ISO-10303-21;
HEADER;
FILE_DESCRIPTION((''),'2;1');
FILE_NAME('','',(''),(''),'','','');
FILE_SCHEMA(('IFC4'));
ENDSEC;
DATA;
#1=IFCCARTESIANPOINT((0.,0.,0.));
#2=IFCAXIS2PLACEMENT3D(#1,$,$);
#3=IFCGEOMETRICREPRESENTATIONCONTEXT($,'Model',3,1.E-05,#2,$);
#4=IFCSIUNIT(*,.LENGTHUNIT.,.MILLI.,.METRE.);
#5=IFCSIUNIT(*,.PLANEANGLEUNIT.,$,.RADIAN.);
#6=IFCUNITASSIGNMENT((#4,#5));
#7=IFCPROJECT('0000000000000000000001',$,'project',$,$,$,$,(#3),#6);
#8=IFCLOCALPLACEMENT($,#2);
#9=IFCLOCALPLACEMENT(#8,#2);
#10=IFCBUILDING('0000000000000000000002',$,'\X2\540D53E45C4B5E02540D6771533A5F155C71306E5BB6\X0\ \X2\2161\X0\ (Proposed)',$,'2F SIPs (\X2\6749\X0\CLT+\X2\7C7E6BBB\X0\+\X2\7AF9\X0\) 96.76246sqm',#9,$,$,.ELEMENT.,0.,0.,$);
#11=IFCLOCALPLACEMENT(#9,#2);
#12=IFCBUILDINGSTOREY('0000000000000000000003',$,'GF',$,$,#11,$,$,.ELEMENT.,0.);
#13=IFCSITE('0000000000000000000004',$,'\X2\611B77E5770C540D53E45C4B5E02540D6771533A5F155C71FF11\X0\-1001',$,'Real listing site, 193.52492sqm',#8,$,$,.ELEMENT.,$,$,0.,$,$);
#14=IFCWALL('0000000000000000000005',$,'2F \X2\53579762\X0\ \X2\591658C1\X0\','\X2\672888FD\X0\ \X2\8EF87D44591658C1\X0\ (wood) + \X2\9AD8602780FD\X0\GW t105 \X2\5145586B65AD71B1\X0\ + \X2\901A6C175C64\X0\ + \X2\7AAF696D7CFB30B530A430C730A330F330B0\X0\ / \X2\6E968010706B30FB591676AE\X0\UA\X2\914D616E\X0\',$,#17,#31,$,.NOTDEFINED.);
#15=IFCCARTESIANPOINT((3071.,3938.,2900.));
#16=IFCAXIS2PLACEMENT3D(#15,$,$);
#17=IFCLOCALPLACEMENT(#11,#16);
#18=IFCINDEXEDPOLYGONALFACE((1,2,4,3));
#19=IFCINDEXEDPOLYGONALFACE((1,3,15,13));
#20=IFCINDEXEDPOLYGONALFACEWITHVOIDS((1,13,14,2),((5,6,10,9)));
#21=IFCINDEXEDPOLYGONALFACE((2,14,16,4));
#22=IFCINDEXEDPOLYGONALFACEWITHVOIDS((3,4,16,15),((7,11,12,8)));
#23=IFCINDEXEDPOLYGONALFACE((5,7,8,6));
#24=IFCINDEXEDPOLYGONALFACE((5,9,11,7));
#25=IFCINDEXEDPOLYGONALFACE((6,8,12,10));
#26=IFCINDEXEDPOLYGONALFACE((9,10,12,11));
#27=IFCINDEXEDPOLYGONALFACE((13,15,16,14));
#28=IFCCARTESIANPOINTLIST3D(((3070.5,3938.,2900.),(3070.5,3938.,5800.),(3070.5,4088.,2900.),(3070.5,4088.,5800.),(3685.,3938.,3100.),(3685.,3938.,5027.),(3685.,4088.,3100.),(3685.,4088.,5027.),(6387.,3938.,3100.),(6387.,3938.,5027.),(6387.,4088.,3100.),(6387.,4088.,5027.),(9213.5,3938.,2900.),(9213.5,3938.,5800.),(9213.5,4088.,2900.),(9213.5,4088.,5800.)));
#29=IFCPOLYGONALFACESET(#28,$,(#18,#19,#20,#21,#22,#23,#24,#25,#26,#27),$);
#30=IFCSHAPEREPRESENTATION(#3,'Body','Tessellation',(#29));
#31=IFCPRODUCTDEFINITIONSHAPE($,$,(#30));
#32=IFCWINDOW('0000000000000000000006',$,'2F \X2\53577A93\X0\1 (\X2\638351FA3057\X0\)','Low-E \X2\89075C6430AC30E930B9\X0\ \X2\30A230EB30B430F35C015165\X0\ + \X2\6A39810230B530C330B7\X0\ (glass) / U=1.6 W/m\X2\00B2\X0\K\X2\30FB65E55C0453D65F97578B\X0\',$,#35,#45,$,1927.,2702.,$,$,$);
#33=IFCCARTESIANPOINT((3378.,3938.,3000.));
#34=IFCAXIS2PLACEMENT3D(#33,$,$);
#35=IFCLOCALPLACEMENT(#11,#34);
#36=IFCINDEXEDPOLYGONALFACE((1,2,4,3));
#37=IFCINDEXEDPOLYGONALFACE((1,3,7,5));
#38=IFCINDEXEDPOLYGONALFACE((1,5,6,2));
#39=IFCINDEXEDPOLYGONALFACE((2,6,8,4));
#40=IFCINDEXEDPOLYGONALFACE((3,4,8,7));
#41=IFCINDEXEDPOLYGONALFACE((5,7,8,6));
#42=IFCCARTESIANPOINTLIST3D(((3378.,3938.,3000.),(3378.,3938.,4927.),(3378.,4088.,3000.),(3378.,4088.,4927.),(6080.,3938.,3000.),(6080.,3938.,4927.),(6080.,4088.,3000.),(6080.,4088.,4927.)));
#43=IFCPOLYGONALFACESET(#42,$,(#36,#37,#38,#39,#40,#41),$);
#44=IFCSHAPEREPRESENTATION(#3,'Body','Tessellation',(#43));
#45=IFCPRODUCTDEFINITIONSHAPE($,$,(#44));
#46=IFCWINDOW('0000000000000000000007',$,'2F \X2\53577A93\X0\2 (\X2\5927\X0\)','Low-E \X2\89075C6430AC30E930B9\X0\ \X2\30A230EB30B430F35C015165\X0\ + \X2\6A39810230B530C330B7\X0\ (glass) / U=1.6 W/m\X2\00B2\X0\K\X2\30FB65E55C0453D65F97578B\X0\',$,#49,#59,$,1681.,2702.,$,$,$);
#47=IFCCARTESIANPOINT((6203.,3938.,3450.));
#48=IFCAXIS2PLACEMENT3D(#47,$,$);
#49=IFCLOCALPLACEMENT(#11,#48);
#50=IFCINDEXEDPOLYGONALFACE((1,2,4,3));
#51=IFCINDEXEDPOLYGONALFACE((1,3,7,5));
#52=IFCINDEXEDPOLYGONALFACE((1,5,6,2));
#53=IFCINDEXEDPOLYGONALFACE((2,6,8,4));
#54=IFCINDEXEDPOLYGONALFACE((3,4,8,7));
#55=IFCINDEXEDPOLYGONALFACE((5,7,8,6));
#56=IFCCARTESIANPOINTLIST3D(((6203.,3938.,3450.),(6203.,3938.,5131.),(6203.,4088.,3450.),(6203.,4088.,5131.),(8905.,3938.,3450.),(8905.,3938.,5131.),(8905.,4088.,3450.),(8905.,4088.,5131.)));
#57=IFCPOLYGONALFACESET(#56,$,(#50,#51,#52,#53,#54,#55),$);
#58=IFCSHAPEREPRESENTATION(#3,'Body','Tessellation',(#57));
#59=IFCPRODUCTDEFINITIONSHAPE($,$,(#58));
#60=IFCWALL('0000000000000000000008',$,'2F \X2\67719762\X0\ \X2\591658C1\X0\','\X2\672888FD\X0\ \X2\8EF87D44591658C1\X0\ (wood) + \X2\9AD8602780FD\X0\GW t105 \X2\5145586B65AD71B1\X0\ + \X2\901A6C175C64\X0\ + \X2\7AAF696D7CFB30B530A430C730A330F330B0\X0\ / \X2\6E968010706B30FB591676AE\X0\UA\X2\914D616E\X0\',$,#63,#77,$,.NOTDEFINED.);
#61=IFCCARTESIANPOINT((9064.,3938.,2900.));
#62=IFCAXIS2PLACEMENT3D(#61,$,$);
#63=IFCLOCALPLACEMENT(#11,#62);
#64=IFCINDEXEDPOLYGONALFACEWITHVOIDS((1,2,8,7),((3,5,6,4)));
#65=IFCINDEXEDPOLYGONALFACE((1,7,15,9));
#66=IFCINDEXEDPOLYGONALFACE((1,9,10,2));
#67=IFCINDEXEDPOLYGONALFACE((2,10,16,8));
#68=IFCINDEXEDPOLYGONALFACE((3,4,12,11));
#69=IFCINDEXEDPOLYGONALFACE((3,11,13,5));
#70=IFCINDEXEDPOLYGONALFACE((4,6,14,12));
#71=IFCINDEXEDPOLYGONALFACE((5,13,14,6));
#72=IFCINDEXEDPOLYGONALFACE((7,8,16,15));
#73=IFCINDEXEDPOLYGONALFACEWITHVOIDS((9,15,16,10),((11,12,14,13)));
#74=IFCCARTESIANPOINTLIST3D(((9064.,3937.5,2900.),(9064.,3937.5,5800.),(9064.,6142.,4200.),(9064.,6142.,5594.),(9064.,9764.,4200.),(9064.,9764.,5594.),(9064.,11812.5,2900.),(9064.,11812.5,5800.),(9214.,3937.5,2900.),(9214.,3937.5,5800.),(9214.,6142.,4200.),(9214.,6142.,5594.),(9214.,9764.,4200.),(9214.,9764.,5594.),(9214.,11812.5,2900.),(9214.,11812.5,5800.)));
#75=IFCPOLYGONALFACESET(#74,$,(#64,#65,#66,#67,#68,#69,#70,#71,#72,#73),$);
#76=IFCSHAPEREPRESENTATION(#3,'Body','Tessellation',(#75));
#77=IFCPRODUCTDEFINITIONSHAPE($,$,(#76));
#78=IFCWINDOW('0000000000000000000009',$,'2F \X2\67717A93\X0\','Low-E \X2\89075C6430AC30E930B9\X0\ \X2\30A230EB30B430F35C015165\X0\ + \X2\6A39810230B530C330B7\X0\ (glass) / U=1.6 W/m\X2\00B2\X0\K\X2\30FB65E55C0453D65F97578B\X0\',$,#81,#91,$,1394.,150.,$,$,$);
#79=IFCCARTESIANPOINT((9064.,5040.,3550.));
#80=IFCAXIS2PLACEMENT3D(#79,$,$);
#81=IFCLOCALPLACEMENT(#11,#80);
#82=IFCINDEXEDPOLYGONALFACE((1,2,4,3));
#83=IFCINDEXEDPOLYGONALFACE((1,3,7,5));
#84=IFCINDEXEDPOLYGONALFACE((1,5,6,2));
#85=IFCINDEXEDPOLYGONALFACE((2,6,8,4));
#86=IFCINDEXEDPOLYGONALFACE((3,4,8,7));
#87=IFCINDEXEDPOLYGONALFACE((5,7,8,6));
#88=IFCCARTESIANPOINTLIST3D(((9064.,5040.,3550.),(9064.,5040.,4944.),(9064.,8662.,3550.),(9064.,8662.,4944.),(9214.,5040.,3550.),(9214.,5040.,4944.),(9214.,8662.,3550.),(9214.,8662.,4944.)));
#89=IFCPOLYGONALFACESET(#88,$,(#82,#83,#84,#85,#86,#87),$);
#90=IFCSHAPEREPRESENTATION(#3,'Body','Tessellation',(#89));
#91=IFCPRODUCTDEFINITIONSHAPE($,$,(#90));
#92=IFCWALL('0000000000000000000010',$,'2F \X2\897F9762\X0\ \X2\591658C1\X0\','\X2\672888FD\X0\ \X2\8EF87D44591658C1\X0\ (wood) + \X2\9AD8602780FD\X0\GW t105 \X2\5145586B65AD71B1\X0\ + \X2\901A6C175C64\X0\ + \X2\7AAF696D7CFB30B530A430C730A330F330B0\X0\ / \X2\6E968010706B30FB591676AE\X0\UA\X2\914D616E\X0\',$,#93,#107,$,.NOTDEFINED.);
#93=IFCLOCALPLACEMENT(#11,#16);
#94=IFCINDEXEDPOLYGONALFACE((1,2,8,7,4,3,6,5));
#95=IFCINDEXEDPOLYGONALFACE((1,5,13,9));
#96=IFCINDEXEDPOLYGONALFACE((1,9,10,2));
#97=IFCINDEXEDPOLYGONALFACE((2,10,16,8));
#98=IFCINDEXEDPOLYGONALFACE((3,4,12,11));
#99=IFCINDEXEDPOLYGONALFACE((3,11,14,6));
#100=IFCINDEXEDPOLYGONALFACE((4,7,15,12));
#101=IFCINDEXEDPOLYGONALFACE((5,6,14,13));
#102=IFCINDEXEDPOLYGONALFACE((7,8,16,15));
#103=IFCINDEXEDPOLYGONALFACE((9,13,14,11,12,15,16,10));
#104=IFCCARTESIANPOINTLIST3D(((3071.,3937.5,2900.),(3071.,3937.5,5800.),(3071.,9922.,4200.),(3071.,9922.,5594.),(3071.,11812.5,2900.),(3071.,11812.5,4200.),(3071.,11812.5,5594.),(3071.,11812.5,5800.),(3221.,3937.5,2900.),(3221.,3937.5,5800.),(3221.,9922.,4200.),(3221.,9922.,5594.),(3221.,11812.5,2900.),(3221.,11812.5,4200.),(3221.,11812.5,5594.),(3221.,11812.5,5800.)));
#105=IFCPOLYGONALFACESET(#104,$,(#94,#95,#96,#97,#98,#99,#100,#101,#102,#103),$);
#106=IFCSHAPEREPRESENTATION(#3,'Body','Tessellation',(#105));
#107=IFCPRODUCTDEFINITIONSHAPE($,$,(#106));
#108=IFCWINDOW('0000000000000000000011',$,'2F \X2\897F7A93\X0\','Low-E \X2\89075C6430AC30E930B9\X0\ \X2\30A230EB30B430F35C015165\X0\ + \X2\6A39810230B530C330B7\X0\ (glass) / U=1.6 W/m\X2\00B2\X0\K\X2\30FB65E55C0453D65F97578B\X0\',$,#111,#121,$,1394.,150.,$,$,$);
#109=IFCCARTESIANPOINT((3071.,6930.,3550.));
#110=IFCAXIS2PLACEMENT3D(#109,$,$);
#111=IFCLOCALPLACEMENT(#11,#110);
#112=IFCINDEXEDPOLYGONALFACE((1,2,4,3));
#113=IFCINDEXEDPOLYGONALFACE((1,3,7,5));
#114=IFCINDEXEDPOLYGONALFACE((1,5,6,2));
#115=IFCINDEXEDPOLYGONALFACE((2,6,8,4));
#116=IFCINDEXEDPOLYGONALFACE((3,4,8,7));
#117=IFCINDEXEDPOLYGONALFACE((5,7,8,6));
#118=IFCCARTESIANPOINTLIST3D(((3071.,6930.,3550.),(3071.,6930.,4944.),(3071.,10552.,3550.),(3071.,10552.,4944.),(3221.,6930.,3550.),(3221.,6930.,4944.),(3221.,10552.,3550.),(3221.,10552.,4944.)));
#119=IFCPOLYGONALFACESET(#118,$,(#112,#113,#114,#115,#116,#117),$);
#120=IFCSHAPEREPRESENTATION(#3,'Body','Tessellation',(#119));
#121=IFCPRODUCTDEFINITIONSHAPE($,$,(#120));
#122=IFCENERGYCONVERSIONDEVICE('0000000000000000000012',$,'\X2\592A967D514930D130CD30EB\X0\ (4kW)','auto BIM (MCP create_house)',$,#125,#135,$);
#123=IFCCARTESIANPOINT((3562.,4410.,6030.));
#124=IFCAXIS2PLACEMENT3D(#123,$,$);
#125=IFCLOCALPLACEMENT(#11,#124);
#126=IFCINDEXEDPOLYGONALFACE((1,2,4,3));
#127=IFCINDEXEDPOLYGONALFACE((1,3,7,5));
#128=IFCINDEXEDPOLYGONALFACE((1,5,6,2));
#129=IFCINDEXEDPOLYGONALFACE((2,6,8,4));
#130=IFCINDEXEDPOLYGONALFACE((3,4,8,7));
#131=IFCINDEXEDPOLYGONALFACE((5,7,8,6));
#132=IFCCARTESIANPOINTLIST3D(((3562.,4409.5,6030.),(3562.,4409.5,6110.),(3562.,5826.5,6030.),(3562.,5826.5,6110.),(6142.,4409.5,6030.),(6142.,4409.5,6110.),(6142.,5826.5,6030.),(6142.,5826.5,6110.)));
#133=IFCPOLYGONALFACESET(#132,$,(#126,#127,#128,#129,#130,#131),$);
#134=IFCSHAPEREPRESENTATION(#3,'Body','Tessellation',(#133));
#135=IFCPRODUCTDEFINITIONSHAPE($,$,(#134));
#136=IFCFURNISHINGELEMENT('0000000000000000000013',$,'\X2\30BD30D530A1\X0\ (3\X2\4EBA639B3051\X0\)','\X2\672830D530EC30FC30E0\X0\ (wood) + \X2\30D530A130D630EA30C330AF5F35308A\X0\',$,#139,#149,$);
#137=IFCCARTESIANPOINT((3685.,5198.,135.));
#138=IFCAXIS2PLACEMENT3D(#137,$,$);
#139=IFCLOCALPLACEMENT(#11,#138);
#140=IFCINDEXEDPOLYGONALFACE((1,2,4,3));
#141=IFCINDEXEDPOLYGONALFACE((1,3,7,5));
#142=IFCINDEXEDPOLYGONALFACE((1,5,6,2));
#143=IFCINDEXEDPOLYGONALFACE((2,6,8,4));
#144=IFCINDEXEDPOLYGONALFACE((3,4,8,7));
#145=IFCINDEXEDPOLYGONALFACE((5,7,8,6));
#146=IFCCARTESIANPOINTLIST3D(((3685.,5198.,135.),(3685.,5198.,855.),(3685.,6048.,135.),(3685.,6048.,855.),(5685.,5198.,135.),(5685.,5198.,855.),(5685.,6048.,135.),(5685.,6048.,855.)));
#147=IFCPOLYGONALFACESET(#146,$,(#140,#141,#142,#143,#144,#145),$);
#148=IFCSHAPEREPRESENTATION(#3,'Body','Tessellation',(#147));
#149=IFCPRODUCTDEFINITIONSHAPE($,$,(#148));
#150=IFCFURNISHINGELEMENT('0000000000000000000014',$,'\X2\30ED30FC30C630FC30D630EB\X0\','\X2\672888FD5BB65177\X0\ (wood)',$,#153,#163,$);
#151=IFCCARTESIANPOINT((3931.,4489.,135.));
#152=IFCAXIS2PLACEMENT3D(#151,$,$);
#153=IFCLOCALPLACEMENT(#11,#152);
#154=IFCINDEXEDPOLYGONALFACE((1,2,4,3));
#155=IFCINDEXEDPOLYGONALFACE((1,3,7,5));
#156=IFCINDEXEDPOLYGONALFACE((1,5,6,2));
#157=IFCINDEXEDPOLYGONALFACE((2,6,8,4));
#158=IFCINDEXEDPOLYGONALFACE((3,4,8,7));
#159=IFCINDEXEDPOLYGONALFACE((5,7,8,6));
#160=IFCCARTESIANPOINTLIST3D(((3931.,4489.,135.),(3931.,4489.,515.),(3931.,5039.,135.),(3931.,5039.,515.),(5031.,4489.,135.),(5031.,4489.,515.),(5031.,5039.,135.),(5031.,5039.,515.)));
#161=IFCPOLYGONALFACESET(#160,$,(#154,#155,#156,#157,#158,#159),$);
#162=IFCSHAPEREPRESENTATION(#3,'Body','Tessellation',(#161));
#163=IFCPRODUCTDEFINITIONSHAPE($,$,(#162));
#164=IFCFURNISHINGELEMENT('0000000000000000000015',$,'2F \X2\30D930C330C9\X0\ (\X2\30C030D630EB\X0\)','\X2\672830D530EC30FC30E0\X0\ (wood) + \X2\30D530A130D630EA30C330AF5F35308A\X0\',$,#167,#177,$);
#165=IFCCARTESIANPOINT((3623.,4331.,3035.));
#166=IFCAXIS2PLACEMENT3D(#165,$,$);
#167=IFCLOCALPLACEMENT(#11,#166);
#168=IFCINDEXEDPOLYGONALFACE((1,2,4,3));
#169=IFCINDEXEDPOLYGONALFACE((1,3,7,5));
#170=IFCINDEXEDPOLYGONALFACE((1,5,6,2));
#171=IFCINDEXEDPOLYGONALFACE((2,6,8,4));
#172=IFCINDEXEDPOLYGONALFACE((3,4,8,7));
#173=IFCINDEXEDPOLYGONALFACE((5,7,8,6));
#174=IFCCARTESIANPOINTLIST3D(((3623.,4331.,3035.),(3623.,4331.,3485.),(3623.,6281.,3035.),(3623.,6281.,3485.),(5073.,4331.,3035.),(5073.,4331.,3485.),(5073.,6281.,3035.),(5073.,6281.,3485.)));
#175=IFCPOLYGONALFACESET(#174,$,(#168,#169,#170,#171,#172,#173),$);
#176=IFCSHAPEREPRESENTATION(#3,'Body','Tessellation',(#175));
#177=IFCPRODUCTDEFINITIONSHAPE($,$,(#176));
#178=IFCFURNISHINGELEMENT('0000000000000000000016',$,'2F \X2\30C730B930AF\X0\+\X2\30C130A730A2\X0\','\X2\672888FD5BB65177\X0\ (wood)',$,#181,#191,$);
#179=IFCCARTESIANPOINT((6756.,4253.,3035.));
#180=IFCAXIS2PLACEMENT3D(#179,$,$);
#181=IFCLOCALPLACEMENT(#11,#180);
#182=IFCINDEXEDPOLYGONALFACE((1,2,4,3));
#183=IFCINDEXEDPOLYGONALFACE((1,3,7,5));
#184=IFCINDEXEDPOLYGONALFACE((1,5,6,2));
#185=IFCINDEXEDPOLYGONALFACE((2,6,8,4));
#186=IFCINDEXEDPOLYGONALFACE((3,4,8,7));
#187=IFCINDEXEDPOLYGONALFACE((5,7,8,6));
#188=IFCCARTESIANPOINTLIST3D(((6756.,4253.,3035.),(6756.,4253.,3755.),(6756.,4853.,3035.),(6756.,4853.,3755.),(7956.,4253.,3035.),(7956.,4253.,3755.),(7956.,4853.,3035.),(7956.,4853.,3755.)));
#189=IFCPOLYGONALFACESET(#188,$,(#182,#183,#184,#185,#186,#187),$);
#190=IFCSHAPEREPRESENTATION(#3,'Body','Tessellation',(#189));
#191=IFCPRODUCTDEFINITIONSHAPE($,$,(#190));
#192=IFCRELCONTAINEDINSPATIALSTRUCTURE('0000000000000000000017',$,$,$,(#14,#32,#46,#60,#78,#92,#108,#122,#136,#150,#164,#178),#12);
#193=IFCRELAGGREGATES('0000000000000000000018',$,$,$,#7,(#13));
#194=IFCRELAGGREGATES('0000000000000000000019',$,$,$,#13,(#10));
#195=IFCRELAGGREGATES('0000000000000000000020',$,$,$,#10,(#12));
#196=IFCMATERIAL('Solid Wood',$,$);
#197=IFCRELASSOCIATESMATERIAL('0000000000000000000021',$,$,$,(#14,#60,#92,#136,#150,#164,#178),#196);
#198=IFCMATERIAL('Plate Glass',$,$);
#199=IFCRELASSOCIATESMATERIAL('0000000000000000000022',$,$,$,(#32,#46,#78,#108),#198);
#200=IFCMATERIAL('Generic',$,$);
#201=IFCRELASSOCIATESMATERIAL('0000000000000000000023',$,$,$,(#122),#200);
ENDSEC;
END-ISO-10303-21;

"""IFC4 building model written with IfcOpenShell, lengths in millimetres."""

from ifc_helpers import new_model, si_unit, frame, frame_2d, origin, place, context, project, spatial, rectangle, extrude, material, element, fill, save


model = new_model("IFC4")

# Units and contexts
model_context = context("Model", 3, precision=1e-05, world=origin())
ifc_project = project(units=[si_unit("LENGTHUNIT", "METRE", prefix="MILLI"), si_unit("PLANEANGLEUNIT", "RADIAN")], contexts=[model_context])

# Site, building, storey
site_placement = place(None, origin())
site = spatial("IfcSite", under=ifc_project, at=site_placement, Name="愛知県名古屋市名東区引山１-1001", ObjectType="Real listing site, 193.52492sqm", CompositionType="ELEMENT", RefElevation=0.0)
building_placement = place(site_placement, origin())
building = spatial("IfcBuilding", under=site, at=building_placement, Name="名古屋市名東区引山の家 Ⅱ (Proposed)", ObjectType="2F SIPs (杉CLT+籾殻+竹) 96.76246sqm", CompositionType="ELEMENT", ElevationOfRefHeight=0.0, ElevationOfTerrain=0.0)
storey_placement = place(building_placement, origin())
storey = spatial("IfcBuildingStorey", under=building, at=storey_placement, Name="GF", CompositionType="ELEMENT", Elevation=0.0)

# Shared definitions
ifc_material_1 = material(Name="Solid Wood")

# Wall, openings, windows
wall_1_placement = place(storey_placement, frame((3071.0, 3938.0, 2900.0)))
wall_1 = element("IfcWall", 1, at=wall_1_placement, inside=storey, material=ifc_material_1, Name="2F 南面 外壁", Description="木製 軸組外壁 (wood) + 高性能GW t105 充填断熱 + 通気層 + 窯業系サイディング / 準耐火・外皮UA配慮", PredefinedType="NOTDEFINED", context=model_context, shape_type="SweptSolid", body=[
    extrude(rectangle(XDim=6143.0, YDim=150.0, at=frame_2d((3071.0, 75.0))), frame((3071.0, 3938.0, 2900.0)), (0.0, 0.0, 1.0), 2900.0),
])
opening_1_placement = place(storey_placement, frame((3378.0, 3938.0, 3000.0)))
opening_1 = element("IfcOpeningElement", 2, at=opening_1_placement, cuts=wall_1, PredefinedType="NOTDEFINED", context=model_context, shape_type="SweptSolid", body=[
    extrude(rectangle(XDim=2702.0, YDim=150.0, at=frame_2d((1351.0, 75.0))), frame((3378.0, 3938.0, 3000.0)), (0.0, 0.0, 1.0), 1927.0),
])
opening_2_placement = place(storey_placement, frame((6203.0, 3938.0, 3450.0)))
opening_2 = element("IfcOpeningElement", 3, at=opening_2_placement, cuts=wall_1, PredefinedType="NOTDEFINED", context=model_context, shape_type="SweptSolid", body=[
    extrude(rectangle(XDim=2702.0, YDim=150.0, at=frame_2d((1351.0, 75.0))), frame((6203.0, 3938.0, 3450.0)), (0.0, 0.0, 1.0), 1681.0),
])
ifc_material_2 = material(Name="Plate Glass")
window_1_placement = place(storey_placement, frame((3378.0, 3938.0, 3000.0)))
window_1 = element("IfcWindow", 4, at=window_1_placement, inside=storey, material=ifc_material_2, Name="2F 南窓1 (掃出し)", Description="Low-E 複層ガラス アルゴン封入 + 樹脂サッシ (glass) / U=1.6 W/m²K・日射取得型", OverallHeight=1927.0, OverallWidth=2702.0, context=model_context, shape_type="SweptSolid", body=[
    extrude(rectangle(XDim=2702.0, YDim=150.0, at=frame_2d((1351.0, 75.0))), frame((3378.0, 3938.0, 3000.0)), (0.0, 0.0, 1.0), 1927.0),
])
fill(opening_1, window_1)
window_2_placement = place(storey_placement, frame((6203.0, 3938.0, 3450.0)))
window_2 = element("IfcWindow", 5, at=window_2_placement, inside=storey, material=ifc_material_2, Name="2F 南窓2 (大)", Description="Low-E 複層ガラス アルゴン封入 + 樹脂サッシ (glass) / U=1.6 W/m²K・日射取得型", OverallHeight=1681.0, OverallWidth=2702.0, context=model_context, shape_type="SweptSolid", body=[
    extrude(rectangle(XDim=2702.0, YDim=150.0, at=frame_2d((1351.0, 75.0))), frame((6203.0, 3938.0, 3450.0)), (0.0, 0.0, 1.0), 1681.0),
])
fill(opening_2, window_2)

# Walls, openings, windows
wall_2_placement = place(storey_placement, frame((9064.0, 3938.0, 2900.0)))
wall_2 = element("IfcWall", 6, at=wall_2_placement, inside=storey, material=ifc_material_1, Name="2F 東面 外壁", Description="木製 軸組外壁 (wood) + 高性能GW t105 充填断熱 + 通気層 + 窯業系サイディング / 準耐火・外皮UA配慮", PredefinedType="NOTDEFINED", context=model_context, shape_type="SweptSolid", body=[
    extrude(rectangle(XDim=150.0, YDim=7875.0, at=frame_2d((75.0, 3937.0))), frame((9064.0, 3938.0, 2900.0)), (0.0, 0.0, 1.0), 2900.0),
])
opening_3_placement = place(storey_placement, frame((9064.0, 5040.0, 3550.0)))
opening_3 = element("IfcOpeningElement", 7, at=opening_3_placement, cuts=wall_2, PredefinedType="NOTDEFINED", context=model_context, shape_type="SweptSolid", body=[
    extrude(rectangle(XDim=150.0, YDim=3622.0, at=frame_2d((75.0, 1811.0))), frame((9064.0, 5040.0, 3550.0)), (0.0, 0.0, 1.0), 1394.0),
])
window_3_placement = place(storey_placement, frame((9064.0, 5040.0, 3550.0)))
window_3 = element("IfcWindow", 8, at=window_3_placement, inside=storey, material=ifc_material_2, Name="2F 東窓", Description="Low-E 複層ガラス アルゴン封入 + 樹脂サッシ (glass) / U=1.6 W/m²K・日射取得型", OverallHeight=1394.0, OverallWidth=150.0, context=model_context, shape_type="SweptSolid", body=[
    extrude(rectangle(XDim=150.0, YDim=3622.0, at=frame_2d((75.0, 1811.0))), frame((9064.0, 5040.0, 3550.0)), (0.0, 0.0, 1.0), 1394.0),
])
fill(opening_3, window_3)
wall_3_placement = place(storey_placement, frame((3071.0, 3938.0, 2900.0)))
wall_3 = element("IfcWall", 9, at=wall_3_placement, inside=storey, material=ifc_material_1, Name="2F 西面 外壁", Description="木製 軸組外壁 (wood) + 高性能GW t105 充填断熱 + 通気層 + 窯業系サイディング / 準耐火・外皮UA配慮", PredefinedType="NOTDEFINED", context=model_context, shape_type="SweptSolid", body=[
    extrude(rectangle(XDim=150.0, YDim=7875.0, at=frame_2d((75.0, 3937.0))), frame((3071.0, 3938.0, 2900.0)), (0.0, 0.0, 1.0), 2900.0),
])
opening_4_placement = place(storey_placement, frame((3071.0, 6930.0, 3550.0)))
opening_4 = element("IfcOpeningElement", 10, at=opening_4_placement, cuts=wall_3, PredefinedType="NOTDEFINED", context=model_context, shape_type="SweptSolid", body=[
    extrude(rectangle(XDim=150.0, YDim=3622.0, at=frame_2d((75.0, 1811.0))), frame((3071.0, 6930.0, 3550.0)), (0.0, 0.0, 1.0), 1394.0),
])
window_4_placement = place(storey_placement, frame((3071.0, 6930.0, 3550.0)))
window_4 = element("IfcWindow", 11, at=window_4_placement, inside=storey, material=ifc_material_2, Name="2F 西窓", Description="Low-E 複層ガラス アルゴン封入 + 樹脂サッシ (glass) / U=1.6 W/m²K・日射取得型", OverallHeight=1394.0, OverallWidth=150.0, context=model_context, shape_type="SweptSolid", body=[
    extrude(rectangle(XDim=150.0, YDim=3622.0, at=frame_2d((75.0, 1811.0))), frame((3071.0, 6930.0, 3550.0)), (0.0, 0.0, 1.0), 1394.0),
])
fill(opening_4, window_4)

# Shared definitions
ifc_material_3 = material(Name="Generic")

# Energy conversion device
energy_conversion_device_placement = place(storey_placement, frame((3562.0, 4410.0, 6030.0)))
element("IfcEnergyConversionDevice", 12, at=energy_conversion_device_placement, inside=storey, material=ifc_material_3, Name="太陽光パネル (4kW)", Description="auto BIM (MCP create_house)", context=model_context, shape_type="SweptSolid", body=[
    extrude(rectangle(XDim=2580.0, YDim=1417.0, at=frame_2d((1290.0, 708.0))), frame((3562.0, 4410.0, 6030.0)), (0.0, 0.0, 1.0), 80.0),
])

# Furnishing elements
furnishing_1_placement = place(storey_placement, frame((3685.0, 5198.0, 135.0)))
element("IfcFurnishingElement", 13, at=furnishing_1_placement, inside=storey, material=ifc_material_1, Name="ソファ (3人掛け)", Description="木フレーム (wood) + ファブリック張り", context=model_context, shape_type="SweptSolid", body=[
    extrude(rectangle(XDim=2000.0, YDim=850.0, at=frame_2d((1000.0, 425.0))), frame((3685.0, 5198.0, 135.0)), (0.0, 0.0, 1.0), 720.0),
])
furnishing_2_placement = place(storey_placement, frame((3931.0, 4489.0, 135.0)))
element("IfcFurnishingElement", 14, at=furnishing_2_placement, inside=storey, material=ifc_material_1, Name="ローテーブル", Description="木製家具 (wood)", context=model_context, shape_type="SweptSolid", body=[
    extrude(rectangle(XDim=1100.0, YDim=550.0, at=frame_2d((550.0, 275.0))), frame((3931.0, 4489.0, 135.0)), (0.0, 0.0, 1.0), 380.0),
])
furnishing_3_placement = place(storey_placement, frame((3623.0, 4331.0, 3035.0)))
element("IfcFurnishingElement", 15, at=furnishing_3_placement, inside=storey, material=ifc_material_1, Name="2F ベッド (ダブル)", Description="木フレーム (wood) + ファブリック張り", context=model_context, shape_type="SweptSolid", body=[
    extrude(rectangle(XDim=1450.0, YDim=1950.0, at=frame_2d((725.0, 975.0))), frame((3623.0, 4331.0, 3035.0)), (0.0, 0.0, 1.0), 450.0),
])
furnishing_4_placement = place(storey_placement, frame((6756.0, 4253.0, 3035.0)))
element("IfcFurnishingElement", 16, at=furnishing_4_placement, inside=storey, material=ifc_material_1, Name="2F デスク+チェア", Description="木製家具 (wood)", context=model_context, shape_type="SweptSolid", body=[
    extrude(rectangle(XDim=1200.0, YDim=600.0, at=frame_2d((600.0, 300.0))), frame((6756.0, 4253.0, 3035.0)), (0.0, 0.0, 1.0), 720.0),
])

save(model, "model.ifc")
